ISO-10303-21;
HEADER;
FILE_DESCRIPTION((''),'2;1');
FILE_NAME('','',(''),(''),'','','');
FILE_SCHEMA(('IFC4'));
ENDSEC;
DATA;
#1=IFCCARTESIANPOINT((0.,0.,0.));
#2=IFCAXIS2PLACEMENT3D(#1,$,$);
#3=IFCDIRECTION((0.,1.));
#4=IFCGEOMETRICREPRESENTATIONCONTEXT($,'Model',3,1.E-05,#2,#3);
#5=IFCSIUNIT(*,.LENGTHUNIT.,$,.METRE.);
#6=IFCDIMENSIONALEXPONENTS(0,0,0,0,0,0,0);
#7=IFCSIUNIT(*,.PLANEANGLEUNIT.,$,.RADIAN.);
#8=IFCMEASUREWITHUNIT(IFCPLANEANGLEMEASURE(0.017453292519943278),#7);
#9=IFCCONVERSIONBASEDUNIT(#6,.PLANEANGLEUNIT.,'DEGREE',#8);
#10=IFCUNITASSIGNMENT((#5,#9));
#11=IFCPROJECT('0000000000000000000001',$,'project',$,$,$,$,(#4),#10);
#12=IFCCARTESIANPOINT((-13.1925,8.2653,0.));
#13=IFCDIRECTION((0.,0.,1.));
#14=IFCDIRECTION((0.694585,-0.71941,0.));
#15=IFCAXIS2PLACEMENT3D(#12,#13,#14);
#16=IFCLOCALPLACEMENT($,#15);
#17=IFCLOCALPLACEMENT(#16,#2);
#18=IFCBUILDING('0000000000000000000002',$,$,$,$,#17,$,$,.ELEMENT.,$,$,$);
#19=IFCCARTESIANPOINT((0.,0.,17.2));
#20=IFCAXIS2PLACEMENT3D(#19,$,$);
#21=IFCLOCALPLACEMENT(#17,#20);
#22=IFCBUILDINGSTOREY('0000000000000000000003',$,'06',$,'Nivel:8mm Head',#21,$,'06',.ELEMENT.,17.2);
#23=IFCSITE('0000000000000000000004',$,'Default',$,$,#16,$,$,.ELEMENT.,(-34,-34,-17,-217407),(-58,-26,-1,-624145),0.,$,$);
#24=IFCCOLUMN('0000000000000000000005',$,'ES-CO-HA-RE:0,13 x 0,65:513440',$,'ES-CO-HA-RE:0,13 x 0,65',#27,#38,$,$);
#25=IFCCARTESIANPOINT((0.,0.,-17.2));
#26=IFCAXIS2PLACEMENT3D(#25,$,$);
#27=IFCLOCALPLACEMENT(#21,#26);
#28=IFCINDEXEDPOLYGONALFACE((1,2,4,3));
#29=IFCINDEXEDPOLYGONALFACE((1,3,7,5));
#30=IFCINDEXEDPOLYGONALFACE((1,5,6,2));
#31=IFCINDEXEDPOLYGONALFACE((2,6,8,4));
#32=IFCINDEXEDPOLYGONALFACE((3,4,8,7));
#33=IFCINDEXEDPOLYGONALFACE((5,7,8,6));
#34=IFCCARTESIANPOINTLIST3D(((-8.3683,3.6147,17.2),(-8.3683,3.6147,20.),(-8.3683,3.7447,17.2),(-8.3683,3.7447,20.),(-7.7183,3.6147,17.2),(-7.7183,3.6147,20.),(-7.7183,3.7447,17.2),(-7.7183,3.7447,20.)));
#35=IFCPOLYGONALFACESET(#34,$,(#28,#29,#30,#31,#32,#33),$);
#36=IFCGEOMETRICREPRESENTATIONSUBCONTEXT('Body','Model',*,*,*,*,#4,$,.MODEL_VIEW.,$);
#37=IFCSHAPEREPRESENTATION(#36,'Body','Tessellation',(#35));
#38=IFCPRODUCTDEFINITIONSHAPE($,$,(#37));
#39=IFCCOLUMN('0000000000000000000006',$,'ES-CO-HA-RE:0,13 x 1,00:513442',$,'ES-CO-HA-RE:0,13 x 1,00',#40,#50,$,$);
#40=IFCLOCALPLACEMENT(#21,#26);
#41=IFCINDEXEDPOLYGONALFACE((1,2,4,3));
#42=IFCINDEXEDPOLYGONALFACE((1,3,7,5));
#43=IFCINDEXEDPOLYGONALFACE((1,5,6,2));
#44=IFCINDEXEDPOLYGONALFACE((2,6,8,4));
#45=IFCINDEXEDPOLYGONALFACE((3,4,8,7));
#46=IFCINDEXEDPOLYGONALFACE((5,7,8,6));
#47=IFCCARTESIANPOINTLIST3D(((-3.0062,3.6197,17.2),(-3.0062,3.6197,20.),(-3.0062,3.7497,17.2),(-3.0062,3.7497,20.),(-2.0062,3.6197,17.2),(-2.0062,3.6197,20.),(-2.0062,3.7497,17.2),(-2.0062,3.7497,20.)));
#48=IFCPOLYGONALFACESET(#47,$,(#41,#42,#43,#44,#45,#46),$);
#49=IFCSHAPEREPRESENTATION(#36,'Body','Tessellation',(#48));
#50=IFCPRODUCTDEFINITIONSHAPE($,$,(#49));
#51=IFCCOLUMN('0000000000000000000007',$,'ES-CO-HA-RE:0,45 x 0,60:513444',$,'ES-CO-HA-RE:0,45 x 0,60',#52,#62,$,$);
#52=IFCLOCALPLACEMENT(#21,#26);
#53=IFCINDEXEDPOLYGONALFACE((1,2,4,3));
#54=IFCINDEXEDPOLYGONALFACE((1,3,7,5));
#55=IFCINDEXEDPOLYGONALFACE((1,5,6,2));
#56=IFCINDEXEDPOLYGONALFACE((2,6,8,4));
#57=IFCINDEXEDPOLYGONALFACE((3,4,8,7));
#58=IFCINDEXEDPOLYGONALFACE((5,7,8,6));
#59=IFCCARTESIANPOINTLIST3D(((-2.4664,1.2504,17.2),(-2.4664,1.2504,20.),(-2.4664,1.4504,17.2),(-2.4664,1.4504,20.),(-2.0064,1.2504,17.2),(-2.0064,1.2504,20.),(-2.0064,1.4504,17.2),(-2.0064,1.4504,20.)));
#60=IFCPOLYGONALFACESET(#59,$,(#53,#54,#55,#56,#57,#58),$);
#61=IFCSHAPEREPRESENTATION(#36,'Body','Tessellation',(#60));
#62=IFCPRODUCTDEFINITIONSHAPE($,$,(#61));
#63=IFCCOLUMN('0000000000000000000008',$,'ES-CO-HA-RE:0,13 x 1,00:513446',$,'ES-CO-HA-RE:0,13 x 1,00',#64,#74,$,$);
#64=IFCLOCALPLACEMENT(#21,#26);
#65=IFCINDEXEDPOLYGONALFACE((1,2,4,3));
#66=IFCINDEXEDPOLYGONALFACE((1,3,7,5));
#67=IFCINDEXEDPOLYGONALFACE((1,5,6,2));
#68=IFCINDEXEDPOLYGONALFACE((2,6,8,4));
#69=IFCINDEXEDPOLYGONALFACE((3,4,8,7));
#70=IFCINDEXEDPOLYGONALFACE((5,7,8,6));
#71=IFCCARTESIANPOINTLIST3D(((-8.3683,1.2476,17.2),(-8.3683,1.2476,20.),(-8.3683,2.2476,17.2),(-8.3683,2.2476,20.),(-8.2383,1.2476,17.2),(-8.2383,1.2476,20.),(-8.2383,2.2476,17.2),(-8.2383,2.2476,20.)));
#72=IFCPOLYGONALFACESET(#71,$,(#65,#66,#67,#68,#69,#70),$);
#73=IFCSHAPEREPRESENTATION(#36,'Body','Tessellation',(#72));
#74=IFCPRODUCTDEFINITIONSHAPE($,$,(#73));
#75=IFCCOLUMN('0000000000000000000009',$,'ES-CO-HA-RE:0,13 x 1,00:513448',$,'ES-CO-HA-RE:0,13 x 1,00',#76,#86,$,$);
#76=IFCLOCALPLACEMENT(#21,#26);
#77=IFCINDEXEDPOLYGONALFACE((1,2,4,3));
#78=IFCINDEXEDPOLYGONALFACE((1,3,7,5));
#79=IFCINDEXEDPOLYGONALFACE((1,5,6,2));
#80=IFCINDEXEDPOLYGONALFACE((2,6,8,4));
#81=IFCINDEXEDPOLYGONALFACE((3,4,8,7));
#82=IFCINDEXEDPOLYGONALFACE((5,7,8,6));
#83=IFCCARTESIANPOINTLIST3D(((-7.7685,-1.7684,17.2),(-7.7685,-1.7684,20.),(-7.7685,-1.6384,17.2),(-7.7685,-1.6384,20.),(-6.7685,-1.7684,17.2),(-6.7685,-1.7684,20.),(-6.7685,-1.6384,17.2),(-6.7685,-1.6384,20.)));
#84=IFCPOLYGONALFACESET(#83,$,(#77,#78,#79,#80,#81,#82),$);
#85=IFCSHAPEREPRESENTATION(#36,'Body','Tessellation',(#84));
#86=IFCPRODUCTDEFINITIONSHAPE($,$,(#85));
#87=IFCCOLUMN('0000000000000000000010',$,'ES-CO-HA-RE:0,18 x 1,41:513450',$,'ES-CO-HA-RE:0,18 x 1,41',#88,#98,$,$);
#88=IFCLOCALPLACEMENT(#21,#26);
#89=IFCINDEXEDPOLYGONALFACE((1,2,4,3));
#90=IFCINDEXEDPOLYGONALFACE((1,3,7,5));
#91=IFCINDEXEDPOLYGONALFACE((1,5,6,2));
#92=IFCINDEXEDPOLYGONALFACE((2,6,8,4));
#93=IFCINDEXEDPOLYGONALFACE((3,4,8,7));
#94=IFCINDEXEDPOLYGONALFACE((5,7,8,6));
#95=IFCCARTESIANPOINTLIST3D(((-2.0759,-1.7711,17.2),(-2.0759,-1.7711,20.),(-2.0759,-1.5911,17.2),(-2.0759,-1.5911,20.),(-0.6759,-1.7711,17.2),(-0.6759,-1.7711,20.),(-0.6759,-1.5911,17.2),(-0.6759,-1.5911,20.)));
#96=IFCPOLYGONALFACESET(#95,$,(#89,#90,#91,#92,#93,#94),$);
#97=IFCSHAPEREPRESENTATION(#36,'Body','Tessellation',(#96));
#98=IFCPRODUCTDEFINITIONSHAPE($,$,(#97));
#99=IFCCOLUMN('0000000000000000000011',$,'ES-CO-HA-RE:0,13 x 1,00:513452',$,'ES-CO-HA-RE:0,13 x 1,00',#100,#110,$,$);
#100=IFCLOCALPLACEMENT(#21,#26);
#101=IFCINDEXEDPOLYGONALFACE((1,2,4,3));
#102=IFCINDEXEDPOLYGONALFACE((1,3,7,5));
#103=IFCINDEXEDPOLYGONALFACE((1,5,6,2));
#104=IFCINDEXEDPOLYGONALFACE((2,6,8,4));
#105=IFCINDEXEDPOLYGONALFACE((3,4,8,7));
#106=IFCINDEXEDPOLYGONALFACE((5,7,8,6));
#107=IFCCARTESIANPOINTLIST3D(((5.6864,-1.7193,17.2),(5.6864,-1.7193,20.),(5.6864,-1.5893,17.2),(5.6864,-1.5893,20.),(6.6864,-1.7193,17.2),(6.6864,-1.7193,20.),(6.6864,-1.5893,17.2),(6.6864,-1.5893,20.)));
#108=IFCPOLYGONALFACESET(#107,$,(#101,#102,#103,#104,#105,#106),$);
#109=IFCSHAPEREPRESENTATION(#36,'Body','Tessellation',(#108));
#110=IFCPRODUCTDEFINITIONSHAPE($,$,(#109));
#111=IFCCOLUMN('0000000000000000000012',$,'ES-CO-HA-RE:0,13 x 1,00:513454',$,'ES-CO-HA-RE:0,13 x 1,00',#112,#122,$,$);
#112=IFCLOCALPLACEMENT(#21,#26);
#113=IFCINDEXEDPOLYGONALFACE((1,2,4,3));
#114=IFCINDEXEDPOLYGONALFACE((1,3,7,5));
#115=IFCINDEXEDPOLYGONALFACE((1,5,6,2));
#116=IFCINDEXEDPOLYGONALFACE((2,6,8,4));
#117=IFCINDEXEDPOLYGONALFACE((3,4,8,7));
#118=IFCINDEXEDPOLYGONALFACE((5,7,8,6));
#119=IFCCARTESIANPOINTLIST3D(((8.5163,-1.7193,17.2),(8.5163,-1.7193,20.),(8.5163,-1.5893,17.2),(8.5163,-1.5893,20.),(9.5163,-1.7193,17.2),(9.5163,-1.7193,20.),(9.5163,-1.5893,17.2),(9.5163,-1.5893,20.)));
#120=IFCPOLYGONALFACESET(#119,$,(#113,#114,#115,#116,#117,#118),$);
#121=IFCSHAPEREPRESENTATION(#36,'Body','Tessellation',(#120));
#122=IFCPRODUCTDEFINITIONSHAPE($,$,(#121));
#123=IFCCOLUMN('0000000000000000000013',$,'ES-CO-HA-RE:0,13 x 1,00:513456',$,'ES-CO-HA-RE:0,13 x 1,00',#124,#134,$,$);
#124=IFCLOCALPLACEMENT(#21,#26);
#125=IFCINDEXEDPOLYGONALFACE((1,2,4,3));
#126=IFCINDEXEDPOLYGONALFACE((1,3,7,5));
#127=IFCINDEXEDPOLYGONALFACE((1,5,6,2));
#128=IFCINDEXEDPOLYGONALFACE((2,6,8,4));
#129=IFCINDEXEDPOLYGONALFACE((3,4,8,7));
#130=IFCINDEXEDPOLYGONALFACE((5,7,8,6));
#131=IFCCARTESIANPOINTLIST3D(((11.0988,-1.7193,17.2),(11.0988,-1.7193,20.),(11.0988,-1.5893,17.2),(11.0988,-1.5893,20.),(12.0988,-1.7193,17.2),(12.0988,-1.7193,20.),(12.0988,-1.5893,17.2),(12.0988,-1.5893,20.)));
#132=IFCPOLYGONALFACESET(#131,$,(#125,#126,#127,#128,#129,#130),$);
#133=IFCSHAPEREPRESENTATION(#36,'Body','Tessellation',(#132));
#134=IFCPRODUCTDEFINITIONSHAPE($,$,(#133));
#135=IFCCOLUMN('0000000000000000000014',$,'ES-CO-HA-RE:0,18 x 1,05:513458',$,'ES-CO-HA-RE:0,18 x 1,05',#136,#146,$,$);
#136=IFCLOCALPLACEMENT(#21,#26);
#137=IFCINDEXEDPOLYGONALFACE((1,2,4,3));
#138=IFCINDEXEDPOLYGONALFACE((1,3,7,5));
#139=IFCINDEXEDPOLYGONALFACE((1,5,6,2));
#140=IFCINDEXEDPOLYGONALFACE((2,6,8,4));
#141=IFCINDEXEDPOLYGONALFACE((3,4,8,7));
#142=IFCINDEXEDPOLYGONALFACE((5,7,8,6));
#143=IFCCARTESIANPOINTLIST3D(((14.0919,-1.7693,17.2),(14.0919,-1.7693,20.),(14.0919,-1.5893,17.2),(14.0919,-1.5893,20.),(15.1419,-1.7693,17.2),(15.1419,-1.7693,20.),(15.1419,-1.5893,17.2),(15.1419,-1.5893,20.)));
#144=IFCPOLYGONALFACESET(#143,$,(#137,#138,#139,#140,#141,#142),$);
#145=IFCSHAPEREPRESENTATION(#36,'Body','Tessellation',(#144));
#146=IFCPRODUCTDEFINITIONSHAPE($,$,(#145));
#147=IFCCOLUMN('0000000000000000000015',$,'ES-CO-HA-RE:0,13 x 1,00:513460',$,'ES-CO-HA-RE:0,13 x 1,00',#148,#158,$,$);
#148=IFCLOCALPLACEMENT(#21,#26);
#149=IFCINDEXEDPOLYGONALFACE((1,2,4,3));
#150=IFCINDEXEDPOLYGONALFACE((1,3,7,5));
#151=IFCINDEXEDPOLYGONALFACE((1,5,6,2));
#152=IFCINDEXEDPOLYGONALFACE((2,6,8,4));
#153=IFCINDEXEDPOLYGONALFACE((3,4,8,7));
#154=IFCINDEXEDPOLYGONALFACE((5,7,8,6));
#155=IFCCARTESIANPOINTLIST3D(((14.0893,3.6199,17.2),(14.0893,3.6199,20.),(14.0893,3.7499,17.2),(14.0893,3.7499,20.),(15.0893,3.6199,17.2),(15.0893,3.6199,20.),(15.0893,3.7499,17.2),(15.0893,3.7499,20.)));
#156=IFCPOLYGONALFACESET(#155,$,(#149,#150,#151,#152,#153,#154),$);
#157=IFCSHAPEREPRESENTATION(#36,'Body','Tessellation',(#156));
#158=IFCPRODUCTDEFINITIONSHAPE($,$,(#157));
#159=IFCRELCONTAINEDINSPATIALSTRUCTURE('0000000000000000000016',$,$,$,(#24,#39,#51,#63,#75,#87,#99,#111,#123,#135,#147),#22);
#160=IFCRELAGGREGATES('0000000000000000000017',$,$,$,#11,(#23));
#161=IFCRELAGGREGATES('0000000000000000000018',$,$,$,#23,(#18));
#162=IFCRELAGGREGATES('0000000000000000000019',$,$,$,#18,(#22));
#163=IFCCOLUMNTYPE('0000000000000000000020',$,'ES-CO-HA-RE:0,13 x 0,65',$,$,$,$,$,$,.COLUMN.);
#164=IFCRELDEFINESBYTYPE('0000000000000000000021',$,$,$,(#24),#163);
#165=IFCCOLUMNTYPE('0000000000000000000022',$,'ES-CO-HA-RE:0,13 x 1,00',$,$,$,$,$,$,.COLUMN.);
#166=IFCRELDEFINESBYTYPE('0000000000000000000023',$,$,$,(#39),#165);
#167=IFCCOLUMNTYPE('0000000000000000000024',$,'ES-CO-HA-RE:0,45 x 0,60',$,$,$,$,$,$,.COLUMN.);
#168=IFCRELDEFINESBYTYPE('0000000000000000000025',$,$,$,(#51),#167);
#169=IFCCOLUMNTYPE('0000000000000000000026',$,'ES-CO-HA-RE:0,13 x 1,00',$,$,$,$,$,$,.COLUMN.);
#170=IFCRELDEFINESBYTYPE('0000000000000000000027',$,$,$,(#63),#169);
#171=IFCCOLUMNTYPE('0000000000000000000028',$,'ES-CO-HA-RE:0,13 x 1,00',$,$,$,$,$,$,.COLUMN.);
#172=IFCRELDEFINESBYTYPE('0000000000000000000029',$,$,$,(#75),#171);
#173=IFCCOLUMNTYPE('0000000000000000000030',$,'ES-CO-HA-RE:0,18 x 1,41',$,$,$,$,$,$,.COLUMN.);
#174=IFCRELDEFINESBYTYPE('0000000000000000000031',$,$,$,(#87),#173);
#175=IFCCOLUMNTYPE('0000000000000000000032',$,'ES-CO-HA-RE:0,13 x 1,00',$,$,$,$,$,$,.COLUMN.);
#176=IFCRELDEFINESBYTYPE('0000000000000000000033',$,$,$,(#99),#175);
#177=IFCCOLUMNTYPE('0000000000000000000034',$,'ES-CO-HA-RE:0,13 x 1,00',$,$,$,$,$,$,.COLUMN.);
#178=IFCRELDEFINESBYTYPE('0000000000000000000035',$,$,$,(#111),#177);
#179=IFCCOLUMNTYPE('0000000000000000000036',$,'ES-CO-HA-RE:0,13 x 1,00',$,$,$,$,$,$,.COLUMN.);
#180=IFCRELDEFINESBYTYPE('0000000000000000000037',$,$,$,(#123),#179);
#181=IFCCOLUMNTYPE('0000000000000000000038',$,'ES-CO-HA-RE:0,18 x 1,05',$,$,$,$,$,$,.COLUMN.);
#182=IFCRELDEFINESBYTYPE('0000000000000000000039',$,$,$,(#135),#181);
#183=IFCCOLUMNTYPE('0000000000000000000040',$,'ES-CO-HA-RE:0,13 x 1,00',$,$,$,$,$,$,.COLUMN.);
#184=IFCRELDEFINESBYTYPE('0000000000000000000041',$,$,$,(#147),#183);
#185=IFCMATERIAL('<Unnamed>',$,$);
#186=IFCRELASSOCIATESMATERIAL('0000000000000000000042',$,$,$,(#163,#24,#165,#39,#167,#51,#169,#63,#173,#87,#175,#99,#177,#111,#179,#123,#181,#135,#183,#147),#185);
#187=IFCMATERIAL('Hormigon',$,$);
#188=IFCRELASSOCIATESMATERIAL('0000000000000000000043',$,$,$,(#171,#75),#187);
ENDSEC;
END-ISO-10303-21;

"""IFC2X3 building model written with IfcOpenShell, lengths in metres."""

from ifc_helpers import new_model, entity, si_unit, converted_unit, direction, frame, frame_2d, origin, origin_2d_with_axis, place, context, subcontext, project, spatial, rectangle, extrude, source, transform, mapped, material, type_object, type_shapes, element, save


model = new_model("IFC2X3")

# Units and contexts
model_context = context("Model", 3, precision=1e-05, world=origin(), true_north=direction((0.0, 1.0)))
body_context = subcontext(model_context, "Body", "Model", "MODEL_VIEW")
ifc_project = project(units=[si_unit("LENGTHUNIT", "METRE"), converted_unit("PLANEANGLEUNIT", "DEGREE", entity("IfcPlaneAngleMeasure", 0.017453292519943278), si_unit("PLANEANGLEUNIT", "RADIAN"), dimensions=[0, 0, 0, 0, 0, 0, 0])], contexts=[model_context])

# Site, building, storey
site_placement = place(None, frame((-13.1925, 8.2653, 0.0), z_axis=(0.0, 0.0, 1.0), x_axis=(0.694585, -0.71941, 0.0)))
site = spatial("IfcSite", under=ifc_project, at=site_placement, Name="Default", CompositionType="ELEMENT", RefLatitude=(-34, -34, -17, -217407), RefLongitude=(-58, -26, -1, -624145), RefElevation=0.0)
building_placement = place(site_placement, origin())
building = spatial("IfcBuilding", under=site, at=building_placement, CompositionType="ELEMENT")
storey_placement = place(building_placement, frame((0.0, 0.0, 17.2)))
storey = spatial("IfcBuildingStorey", under=building, at=storey_placement, Name="06", ObjectType="Nivel:8mm Head", LongName="06", CompositionType="ELEMENT", Elevation=17.2)

# Columns
ifc_material_1 = material(Name="<Unnamed>")
column_type_1 = type_object("IfcColumnType", Name="ES-CO-HA-RE:0,13 x 0,65", PredefinedType="COLUMN", material=ifc_material_1)
shared_shape_1 = source(origin(), body_context, "Body", "SweptSolid", [
    extrude(rectangle(XDim=0.65, YDim=0.13, at=origin_2d_with_axis()), frame((-8.0433, 3.6797, 17.2), z_axis=(0.0, 0.0, 1.0), x_axis=(-1.0, 0.0, 0.0)), (0.0, 0.0, 1.0), 2.8),
])
type_shapes(column_type_1, [shared_shape_1])
column_1_placement = place(storey_placement, frame((0.0, 0.0, -17.2)))
element("IfcColumn", 1, at=column_1_placement, inside=storey, type_object=column_type_1, material=ifc_material_1, Name="ES-CO-HA-RE:0,13 x 0,65:513440", ObjectType="ES-CO-HA-RE:0,13 x 0,65", context=body_context, shape_type="MappedRepresentation", body=[
    mapped(shared_shape_1, transform((0.0, 0.0, 0.0), scale=1.0)),
])
column_type_2 = type_object("IfcColumnType", Name="ES-CO-HA-RE:0,13 x 1,00", PredefinedType="COLUMN", material=ifc_material_1)
shared_shape_2 = source(origin(), body_context, "Body", "SweptSolid", [
    extrude(rectangle(XDim=1.0, YDim=0.13, at=frame_2d((0.0, 0.0), x_axis=(1.0, 0.0))), frame((-2.5062, 3.6847, 17.2), z_axis=(0.0, 0.0, 1.0), x_axis=(-1.0, 0.0, 0.0)), (0.0, 0.0, 1.0), 2.8),
])
type_shapes(column_type_2, [shared_shape_2])
column_2_placement = place(storey_placement, frame((0.0, 0.0, -17.2)))
element("IfcColumn", 2, at=column_2_placement, inside=storey, type_object=column_type_2, material=ifc_material_1, Name="ES-CO-HA-RE:0,13 x 1,00:513442", ObjectType="ES-CO-HA-RE:0,13 x 1,00", context=body_context, shape_type="MappedRepresentation", body=[
    mapped(shared_shape_2, transform((0.0, 0.0, 0.0), scale=1.0)),
])
column_type_3 = type_object("IfcColumnType", Name="ES-CO-HA-RE:0,45 x 0,60", PredefinedType="COLUMN", material=ifc_material_1)
shared_shape_3 = source(origin(), body_context, "Body", "SweptSolid", [
    extrude(rectangle(XDim=0.46, YDim=0.2, at=frame_2d((0.0, 0.0), x_axis=(1.0, 0.0))), frame((-2.2364, 1.3504, 17.2), z_axis=(0.0, 0.0, 1.0), x_axis=(-1.0, 0.0, 0.0)), (0.0, 0.0, 1.0), 2.8),
])
type_shapes(column_type_3, [shared_shape_3])
column_3_placement = place(storey_placement, frame((0.0, 0.0, -17.2)))
element("IfcColumn", 3, at=column_3_placement, inside=storey, type_object=column_type_3, material=ifc_material_1, Name="ES-CO-HA-RE:0,45 x 0,60:513444", ObjectType="ES-CO-HA-RE:0,45 x 0,60", context=body_context, shape_type="MappedRepresentation", body=[
    mapped(shared_shape_3, transform((0.0, 0.0, 0.0), scale=1.0)),
])
column_type_4 = type_object("IfcColumnType", Name="ES-CO-HA-RE:0,13 x 1,00", PredefinedType="COLUMN", material=ifc_material_1)
shared_shape_4 = source(origin(), body_context, "Body", "SweptSolid", [
    extrude(rectangle(XDim=1.0, YDim=0.13, at=frame_2d((0.0, 0.0), x_axis=(1.0, 0.0))), frame((-8.3033, 1.7476, 17.2), z_axis=(0.0, 0.0, 1.0), x_axis=(0.0, -1.0, 0.0)), (0.0, 0.0, 1.0), 2.8),
])
type_shapes(column_type_4, [shared_shape_4])
column_4_placement = place(storey_placement, frame((0.0, 0.0, -17.2)))
element("IfcColumn", 4, at=column_4_placement, inside=storey, type_object=column_type_4, material=ifc_material_1, Name="ES-CO-HA-RE:0,13 x 1,00:513446", ObjectType="ES-CO-HA-RE:0,13 x 1,00", context=body_context, shape_type="MappedRepresentation", body=[
    mapped(shared_shape_4, transform((0.0, 0.0, 0.0), scale=1.0)),
])
ifc_material_2 = material(Name="Hormigon")
column_type_5 = type_object("IfcColumnType", Name="ES-CO-HA-RE:0,13 x 1,00", PredefinedType="COLUMN", material=ifc_material_2)
shared_shape_5 = source(origin(), body_context, "Body", "SweptSolid", [
    extrude(rectangle(XDim=1.0, YDim=0.13, at=frame_2d((0.0, 0.0), x_axis=(1.0, 0.0))), frame((-7.2685, -1.7034, 17.2), z_axis=(0.0, 0.0, 1.0), x_axis=(-1.0, 0.0, 0.0)), (0.0, 0.0, 1.0), 2.8),
])
type_shapes(column_type_5, [shared_shape_5])
column_5_placement = place(storey_placement, frame((0.0, 0.0, -17.2)))
element("IfcColumn", 5, at=column_5_placement, inside=storey, type_object=column_type_5, material=ifc_material_2, Name="ES-CO-HA-RE:0,13 x 1,00:513448", ObjectType="ES-CO-HA-RE:0,13 x 1,00", context=body_context, shape_type="MappedRepresentation", body=[
    mapped(shared_shape_5, transform((0.0, 0.0, 0.0), scale=1.0)),
])
column_type_6 = type_object("IfcColumnType", Name="ES-CO-HA-RE:0,18 x 1,41", PredefinedType="COLUMN", material=ifc_material_1)
shared_shape_6 = source(origin(), body_context, "Body", "SweptSolid", [
    extrude(rectangle(XDim=1.4, YDim=0.18, at=frame_2d((0.0, 0.0), x_axis=(1.0, 0.0))), frame((-1.3759, -1.6811, 17.2), z_axis=(0.0, 0.0, 1.0), x_axis=(-1.0, 0.0, 0.0)), (0.0, 0.0, 1.0), 2.8),
])
type_shapes(column_type_6, [shared_shape_6])
column_6_placement = place(storey_placement, frame((0.0, 0.0, -17.2)))
element("IfcColumn", 6, at=column_6_placement, inside=storey, type_object=column_type_6, material=ifc_material_1, Name="ES-CO-HA-RE:0,18 x 1,41:513450", ObjectType="ES-CO-HA-RE:0,18 x 1,41", context=body_context, shape_type="MappedRepresentation", body=[
    mapped(shared_shape_6, transform((0.0, 0.0, 0.0), scale=1.0)),
])
column_type_7 = type_object("IfcColumnType", Name="ES-CO-HA-RE:0,13 x 1,00", PredefinedType="COLUMN", material=ifc_material_1)
shared_shape_7 = source(origin(), body_context, "Body", "SweptSolid", [
    extrude(rectangle(XDim=1.0, YDim=0.13, at=frame_2d((0.0, 0.0), x_axis=(1.0, 0.0))), frame((6.1864, -1.6543, 17.2), z_axis=(0.0, 0.0, 1.0), x_axis=(-1.0, 0.0, 0.0)), (0.0, 0.0, 1.0), 2.8),
])
type_shapes(column_type_7, [shared_shape_7])
column_7_placement = place(storey_placement, frame((0.0, 0.0, -17.2)))
element("IfcColumn", 7, at=column_7_placement, inside=storey, type_object=column_type_7, material=ifc_material_1, Name="ES-CO-HA-RE:0,13 x 1,00:513452", ObjectType="ES-CO-HA-RE:0,13 x 1,00", context=body_context, shape_type="MappedRepresentation", body=[
    mapped(shared_shape_7, transform((0.0, 0.0, 0.0), scale=1.0)),
])
column_type_8 = type_object("IfcColumnType", Name="ES-CO-HA-RE:0,13 x 1,00", PredefinedType="COLUMN", material=ifc_material_1)
shared_shape_8 = source(origin(), body_context, "Body", "SweptSolid", [
    extrude(rectangle(XDim=1.0, YDim=0.13, at=frame_2d((0.0, 0.0), x_axis=(1.0, 0.0))), frame((9.0163, -1.6543, 17.2), z_axis=(0.0, 0.0, 1.0), x_axis=(-1.0, 0.0, 0.0)), (0.0, 0.0, 1.0), 2.8),
])
type_shapes(column_type_8, [shared_shape_8])
column_8_placement = place(storey_placement, frame((0.0, 0.0, -17.2)))
element("IfcColumn", 8, at=column_8_placement, inside=storey, type_object=column_type_8, material=ifc_material_1, Name="ES-CO-HA-RE:0,13 x 1,00:513454", ObjectType="ES-CO-HA-RE:0,13 x 1,00", context=body_context, shape_type="MappedRepresentation", body=[
    mapped(shared_shape_8, transform((0.0, 0.0, 0.0), scale=1.0)),
])
column_type_9 = type_object("IfcColumnType", Name="ES-CO-HA-RE:0,13 x 1,00", PredefinedType="COLUMN", material=ifc_material_1)
shared_shape_9 = source(origin(), body_context, "Body", "SweptSolid", [
    extrude(rectangle(XDim=1.0, YDim=0.13, at=frame_2d((0.0, 0.0), x_axis=(1.0, 0.0))), frame((11.5988, -1.6543, 17.2), z_axis=(0.0, 0.0, 1.0), x_axis=(-1.0, 0.0, 0.0)), (0.0, 0.0, 1.0), 2.8),
])
type_shapes(column_type_9, [shared_shape_9])
column_9_placement = place(storey_placement, frame((0.0, 0.0, -17.2)))
element("IfcColumn", 9, at=column_9_placement, inside=storey, type_object=column_type_9, material=ifc_material_1, Name="ES-CO-HA-RE:0,13 x 1,00:513456", ObjectType="ES-CO-HA-RE:0,13 x 1,00", context=body_context, shape_type="MappedRepresentation", body=[
    mapped(shared_shape_9, transform((0.0, 0.0, 0.0), scale=1.0)),
])
column_type_10 = type_object("IfcColumnType", Name="ES-CO-HA-RE:0,18 x 1,05", PredefinedType="COLUMN", material=ifc_material_1)
shared_shape_10 = source(origin(), body_context, "Body", "SweptSolid", [
    extrude(rectangle(XDim=1.05, YDim=0.18, at=frame_2d((0.0, 0.0), x_axis=(1.0, 0.0))), frame((14.6169, -1.6793, 17.2), z_axis=(0.0, 0.0, 1.0), x_axis=(-1.0, 0.0, 0.0)), (0.0, 0.0, 1.0), 2.8),
])
type_shapes(column_type_10, [shared_shape_10])
column_10_placement = place(storey_placement, frame((0.0, 0.0, -17.2)))
element("IfcColumn", 10, at=column_10_placement, inside=storey, type_object=column_type_10, material=ifc_material_1, Name="ES-CO-HA-RE:0,18 x 1,05:513458", ObjectType="ES-CO-HA-RE:0,18 x 1,05", context=body_context, shape_type="MappedRepresentation", body=[
    mapped(shared_shape_10, transform((0.0, 0.0, 0.0), scale=1.0)),
])
column_type_11 = type_object("IfcColumnType", Name="ES-CO-HA-RE:0,13 x 1,00", PredefinedType="COLUMN", material=ifc_material_1)
shared_shape_11 = source(origin(), body_context, "Body", "SweptSolid", [
    extrude(rectangle(XDim=1.0, YDim=0.13, at=frame_2d((0.0, 0.0), x_axis=(1.0, 0.0))), frame((14.5893, 3.6849, 17.2), z_axis=(0.0, 0.0, 1.0), x_axis=(-1.0, 0.0, 0.0)), (0.0, 0.0, 1.0), 2.8),
])
type_shapes(column_type_11, [shared_shape_11])
column_11_placement = place(storey_placement, frame((0.0, 0.0, -17.2)))
element("IfcColumn", 11, at=column_11_placement, inside=storey, type_object=column_type_11, material=ifc_material_1, Name="ES-CO-HA-RE:0,13 x 1,00:513460", ObjectType="ES-CO-HA-RE:0,13 x 1,00", context=body_context, shape_type="MappedRepresentation", body=[
    mapped(shared_shape_11, transform((0.0, 0.0, 0.0), scale=1.0)),
])

save(model, "model.ifc")
